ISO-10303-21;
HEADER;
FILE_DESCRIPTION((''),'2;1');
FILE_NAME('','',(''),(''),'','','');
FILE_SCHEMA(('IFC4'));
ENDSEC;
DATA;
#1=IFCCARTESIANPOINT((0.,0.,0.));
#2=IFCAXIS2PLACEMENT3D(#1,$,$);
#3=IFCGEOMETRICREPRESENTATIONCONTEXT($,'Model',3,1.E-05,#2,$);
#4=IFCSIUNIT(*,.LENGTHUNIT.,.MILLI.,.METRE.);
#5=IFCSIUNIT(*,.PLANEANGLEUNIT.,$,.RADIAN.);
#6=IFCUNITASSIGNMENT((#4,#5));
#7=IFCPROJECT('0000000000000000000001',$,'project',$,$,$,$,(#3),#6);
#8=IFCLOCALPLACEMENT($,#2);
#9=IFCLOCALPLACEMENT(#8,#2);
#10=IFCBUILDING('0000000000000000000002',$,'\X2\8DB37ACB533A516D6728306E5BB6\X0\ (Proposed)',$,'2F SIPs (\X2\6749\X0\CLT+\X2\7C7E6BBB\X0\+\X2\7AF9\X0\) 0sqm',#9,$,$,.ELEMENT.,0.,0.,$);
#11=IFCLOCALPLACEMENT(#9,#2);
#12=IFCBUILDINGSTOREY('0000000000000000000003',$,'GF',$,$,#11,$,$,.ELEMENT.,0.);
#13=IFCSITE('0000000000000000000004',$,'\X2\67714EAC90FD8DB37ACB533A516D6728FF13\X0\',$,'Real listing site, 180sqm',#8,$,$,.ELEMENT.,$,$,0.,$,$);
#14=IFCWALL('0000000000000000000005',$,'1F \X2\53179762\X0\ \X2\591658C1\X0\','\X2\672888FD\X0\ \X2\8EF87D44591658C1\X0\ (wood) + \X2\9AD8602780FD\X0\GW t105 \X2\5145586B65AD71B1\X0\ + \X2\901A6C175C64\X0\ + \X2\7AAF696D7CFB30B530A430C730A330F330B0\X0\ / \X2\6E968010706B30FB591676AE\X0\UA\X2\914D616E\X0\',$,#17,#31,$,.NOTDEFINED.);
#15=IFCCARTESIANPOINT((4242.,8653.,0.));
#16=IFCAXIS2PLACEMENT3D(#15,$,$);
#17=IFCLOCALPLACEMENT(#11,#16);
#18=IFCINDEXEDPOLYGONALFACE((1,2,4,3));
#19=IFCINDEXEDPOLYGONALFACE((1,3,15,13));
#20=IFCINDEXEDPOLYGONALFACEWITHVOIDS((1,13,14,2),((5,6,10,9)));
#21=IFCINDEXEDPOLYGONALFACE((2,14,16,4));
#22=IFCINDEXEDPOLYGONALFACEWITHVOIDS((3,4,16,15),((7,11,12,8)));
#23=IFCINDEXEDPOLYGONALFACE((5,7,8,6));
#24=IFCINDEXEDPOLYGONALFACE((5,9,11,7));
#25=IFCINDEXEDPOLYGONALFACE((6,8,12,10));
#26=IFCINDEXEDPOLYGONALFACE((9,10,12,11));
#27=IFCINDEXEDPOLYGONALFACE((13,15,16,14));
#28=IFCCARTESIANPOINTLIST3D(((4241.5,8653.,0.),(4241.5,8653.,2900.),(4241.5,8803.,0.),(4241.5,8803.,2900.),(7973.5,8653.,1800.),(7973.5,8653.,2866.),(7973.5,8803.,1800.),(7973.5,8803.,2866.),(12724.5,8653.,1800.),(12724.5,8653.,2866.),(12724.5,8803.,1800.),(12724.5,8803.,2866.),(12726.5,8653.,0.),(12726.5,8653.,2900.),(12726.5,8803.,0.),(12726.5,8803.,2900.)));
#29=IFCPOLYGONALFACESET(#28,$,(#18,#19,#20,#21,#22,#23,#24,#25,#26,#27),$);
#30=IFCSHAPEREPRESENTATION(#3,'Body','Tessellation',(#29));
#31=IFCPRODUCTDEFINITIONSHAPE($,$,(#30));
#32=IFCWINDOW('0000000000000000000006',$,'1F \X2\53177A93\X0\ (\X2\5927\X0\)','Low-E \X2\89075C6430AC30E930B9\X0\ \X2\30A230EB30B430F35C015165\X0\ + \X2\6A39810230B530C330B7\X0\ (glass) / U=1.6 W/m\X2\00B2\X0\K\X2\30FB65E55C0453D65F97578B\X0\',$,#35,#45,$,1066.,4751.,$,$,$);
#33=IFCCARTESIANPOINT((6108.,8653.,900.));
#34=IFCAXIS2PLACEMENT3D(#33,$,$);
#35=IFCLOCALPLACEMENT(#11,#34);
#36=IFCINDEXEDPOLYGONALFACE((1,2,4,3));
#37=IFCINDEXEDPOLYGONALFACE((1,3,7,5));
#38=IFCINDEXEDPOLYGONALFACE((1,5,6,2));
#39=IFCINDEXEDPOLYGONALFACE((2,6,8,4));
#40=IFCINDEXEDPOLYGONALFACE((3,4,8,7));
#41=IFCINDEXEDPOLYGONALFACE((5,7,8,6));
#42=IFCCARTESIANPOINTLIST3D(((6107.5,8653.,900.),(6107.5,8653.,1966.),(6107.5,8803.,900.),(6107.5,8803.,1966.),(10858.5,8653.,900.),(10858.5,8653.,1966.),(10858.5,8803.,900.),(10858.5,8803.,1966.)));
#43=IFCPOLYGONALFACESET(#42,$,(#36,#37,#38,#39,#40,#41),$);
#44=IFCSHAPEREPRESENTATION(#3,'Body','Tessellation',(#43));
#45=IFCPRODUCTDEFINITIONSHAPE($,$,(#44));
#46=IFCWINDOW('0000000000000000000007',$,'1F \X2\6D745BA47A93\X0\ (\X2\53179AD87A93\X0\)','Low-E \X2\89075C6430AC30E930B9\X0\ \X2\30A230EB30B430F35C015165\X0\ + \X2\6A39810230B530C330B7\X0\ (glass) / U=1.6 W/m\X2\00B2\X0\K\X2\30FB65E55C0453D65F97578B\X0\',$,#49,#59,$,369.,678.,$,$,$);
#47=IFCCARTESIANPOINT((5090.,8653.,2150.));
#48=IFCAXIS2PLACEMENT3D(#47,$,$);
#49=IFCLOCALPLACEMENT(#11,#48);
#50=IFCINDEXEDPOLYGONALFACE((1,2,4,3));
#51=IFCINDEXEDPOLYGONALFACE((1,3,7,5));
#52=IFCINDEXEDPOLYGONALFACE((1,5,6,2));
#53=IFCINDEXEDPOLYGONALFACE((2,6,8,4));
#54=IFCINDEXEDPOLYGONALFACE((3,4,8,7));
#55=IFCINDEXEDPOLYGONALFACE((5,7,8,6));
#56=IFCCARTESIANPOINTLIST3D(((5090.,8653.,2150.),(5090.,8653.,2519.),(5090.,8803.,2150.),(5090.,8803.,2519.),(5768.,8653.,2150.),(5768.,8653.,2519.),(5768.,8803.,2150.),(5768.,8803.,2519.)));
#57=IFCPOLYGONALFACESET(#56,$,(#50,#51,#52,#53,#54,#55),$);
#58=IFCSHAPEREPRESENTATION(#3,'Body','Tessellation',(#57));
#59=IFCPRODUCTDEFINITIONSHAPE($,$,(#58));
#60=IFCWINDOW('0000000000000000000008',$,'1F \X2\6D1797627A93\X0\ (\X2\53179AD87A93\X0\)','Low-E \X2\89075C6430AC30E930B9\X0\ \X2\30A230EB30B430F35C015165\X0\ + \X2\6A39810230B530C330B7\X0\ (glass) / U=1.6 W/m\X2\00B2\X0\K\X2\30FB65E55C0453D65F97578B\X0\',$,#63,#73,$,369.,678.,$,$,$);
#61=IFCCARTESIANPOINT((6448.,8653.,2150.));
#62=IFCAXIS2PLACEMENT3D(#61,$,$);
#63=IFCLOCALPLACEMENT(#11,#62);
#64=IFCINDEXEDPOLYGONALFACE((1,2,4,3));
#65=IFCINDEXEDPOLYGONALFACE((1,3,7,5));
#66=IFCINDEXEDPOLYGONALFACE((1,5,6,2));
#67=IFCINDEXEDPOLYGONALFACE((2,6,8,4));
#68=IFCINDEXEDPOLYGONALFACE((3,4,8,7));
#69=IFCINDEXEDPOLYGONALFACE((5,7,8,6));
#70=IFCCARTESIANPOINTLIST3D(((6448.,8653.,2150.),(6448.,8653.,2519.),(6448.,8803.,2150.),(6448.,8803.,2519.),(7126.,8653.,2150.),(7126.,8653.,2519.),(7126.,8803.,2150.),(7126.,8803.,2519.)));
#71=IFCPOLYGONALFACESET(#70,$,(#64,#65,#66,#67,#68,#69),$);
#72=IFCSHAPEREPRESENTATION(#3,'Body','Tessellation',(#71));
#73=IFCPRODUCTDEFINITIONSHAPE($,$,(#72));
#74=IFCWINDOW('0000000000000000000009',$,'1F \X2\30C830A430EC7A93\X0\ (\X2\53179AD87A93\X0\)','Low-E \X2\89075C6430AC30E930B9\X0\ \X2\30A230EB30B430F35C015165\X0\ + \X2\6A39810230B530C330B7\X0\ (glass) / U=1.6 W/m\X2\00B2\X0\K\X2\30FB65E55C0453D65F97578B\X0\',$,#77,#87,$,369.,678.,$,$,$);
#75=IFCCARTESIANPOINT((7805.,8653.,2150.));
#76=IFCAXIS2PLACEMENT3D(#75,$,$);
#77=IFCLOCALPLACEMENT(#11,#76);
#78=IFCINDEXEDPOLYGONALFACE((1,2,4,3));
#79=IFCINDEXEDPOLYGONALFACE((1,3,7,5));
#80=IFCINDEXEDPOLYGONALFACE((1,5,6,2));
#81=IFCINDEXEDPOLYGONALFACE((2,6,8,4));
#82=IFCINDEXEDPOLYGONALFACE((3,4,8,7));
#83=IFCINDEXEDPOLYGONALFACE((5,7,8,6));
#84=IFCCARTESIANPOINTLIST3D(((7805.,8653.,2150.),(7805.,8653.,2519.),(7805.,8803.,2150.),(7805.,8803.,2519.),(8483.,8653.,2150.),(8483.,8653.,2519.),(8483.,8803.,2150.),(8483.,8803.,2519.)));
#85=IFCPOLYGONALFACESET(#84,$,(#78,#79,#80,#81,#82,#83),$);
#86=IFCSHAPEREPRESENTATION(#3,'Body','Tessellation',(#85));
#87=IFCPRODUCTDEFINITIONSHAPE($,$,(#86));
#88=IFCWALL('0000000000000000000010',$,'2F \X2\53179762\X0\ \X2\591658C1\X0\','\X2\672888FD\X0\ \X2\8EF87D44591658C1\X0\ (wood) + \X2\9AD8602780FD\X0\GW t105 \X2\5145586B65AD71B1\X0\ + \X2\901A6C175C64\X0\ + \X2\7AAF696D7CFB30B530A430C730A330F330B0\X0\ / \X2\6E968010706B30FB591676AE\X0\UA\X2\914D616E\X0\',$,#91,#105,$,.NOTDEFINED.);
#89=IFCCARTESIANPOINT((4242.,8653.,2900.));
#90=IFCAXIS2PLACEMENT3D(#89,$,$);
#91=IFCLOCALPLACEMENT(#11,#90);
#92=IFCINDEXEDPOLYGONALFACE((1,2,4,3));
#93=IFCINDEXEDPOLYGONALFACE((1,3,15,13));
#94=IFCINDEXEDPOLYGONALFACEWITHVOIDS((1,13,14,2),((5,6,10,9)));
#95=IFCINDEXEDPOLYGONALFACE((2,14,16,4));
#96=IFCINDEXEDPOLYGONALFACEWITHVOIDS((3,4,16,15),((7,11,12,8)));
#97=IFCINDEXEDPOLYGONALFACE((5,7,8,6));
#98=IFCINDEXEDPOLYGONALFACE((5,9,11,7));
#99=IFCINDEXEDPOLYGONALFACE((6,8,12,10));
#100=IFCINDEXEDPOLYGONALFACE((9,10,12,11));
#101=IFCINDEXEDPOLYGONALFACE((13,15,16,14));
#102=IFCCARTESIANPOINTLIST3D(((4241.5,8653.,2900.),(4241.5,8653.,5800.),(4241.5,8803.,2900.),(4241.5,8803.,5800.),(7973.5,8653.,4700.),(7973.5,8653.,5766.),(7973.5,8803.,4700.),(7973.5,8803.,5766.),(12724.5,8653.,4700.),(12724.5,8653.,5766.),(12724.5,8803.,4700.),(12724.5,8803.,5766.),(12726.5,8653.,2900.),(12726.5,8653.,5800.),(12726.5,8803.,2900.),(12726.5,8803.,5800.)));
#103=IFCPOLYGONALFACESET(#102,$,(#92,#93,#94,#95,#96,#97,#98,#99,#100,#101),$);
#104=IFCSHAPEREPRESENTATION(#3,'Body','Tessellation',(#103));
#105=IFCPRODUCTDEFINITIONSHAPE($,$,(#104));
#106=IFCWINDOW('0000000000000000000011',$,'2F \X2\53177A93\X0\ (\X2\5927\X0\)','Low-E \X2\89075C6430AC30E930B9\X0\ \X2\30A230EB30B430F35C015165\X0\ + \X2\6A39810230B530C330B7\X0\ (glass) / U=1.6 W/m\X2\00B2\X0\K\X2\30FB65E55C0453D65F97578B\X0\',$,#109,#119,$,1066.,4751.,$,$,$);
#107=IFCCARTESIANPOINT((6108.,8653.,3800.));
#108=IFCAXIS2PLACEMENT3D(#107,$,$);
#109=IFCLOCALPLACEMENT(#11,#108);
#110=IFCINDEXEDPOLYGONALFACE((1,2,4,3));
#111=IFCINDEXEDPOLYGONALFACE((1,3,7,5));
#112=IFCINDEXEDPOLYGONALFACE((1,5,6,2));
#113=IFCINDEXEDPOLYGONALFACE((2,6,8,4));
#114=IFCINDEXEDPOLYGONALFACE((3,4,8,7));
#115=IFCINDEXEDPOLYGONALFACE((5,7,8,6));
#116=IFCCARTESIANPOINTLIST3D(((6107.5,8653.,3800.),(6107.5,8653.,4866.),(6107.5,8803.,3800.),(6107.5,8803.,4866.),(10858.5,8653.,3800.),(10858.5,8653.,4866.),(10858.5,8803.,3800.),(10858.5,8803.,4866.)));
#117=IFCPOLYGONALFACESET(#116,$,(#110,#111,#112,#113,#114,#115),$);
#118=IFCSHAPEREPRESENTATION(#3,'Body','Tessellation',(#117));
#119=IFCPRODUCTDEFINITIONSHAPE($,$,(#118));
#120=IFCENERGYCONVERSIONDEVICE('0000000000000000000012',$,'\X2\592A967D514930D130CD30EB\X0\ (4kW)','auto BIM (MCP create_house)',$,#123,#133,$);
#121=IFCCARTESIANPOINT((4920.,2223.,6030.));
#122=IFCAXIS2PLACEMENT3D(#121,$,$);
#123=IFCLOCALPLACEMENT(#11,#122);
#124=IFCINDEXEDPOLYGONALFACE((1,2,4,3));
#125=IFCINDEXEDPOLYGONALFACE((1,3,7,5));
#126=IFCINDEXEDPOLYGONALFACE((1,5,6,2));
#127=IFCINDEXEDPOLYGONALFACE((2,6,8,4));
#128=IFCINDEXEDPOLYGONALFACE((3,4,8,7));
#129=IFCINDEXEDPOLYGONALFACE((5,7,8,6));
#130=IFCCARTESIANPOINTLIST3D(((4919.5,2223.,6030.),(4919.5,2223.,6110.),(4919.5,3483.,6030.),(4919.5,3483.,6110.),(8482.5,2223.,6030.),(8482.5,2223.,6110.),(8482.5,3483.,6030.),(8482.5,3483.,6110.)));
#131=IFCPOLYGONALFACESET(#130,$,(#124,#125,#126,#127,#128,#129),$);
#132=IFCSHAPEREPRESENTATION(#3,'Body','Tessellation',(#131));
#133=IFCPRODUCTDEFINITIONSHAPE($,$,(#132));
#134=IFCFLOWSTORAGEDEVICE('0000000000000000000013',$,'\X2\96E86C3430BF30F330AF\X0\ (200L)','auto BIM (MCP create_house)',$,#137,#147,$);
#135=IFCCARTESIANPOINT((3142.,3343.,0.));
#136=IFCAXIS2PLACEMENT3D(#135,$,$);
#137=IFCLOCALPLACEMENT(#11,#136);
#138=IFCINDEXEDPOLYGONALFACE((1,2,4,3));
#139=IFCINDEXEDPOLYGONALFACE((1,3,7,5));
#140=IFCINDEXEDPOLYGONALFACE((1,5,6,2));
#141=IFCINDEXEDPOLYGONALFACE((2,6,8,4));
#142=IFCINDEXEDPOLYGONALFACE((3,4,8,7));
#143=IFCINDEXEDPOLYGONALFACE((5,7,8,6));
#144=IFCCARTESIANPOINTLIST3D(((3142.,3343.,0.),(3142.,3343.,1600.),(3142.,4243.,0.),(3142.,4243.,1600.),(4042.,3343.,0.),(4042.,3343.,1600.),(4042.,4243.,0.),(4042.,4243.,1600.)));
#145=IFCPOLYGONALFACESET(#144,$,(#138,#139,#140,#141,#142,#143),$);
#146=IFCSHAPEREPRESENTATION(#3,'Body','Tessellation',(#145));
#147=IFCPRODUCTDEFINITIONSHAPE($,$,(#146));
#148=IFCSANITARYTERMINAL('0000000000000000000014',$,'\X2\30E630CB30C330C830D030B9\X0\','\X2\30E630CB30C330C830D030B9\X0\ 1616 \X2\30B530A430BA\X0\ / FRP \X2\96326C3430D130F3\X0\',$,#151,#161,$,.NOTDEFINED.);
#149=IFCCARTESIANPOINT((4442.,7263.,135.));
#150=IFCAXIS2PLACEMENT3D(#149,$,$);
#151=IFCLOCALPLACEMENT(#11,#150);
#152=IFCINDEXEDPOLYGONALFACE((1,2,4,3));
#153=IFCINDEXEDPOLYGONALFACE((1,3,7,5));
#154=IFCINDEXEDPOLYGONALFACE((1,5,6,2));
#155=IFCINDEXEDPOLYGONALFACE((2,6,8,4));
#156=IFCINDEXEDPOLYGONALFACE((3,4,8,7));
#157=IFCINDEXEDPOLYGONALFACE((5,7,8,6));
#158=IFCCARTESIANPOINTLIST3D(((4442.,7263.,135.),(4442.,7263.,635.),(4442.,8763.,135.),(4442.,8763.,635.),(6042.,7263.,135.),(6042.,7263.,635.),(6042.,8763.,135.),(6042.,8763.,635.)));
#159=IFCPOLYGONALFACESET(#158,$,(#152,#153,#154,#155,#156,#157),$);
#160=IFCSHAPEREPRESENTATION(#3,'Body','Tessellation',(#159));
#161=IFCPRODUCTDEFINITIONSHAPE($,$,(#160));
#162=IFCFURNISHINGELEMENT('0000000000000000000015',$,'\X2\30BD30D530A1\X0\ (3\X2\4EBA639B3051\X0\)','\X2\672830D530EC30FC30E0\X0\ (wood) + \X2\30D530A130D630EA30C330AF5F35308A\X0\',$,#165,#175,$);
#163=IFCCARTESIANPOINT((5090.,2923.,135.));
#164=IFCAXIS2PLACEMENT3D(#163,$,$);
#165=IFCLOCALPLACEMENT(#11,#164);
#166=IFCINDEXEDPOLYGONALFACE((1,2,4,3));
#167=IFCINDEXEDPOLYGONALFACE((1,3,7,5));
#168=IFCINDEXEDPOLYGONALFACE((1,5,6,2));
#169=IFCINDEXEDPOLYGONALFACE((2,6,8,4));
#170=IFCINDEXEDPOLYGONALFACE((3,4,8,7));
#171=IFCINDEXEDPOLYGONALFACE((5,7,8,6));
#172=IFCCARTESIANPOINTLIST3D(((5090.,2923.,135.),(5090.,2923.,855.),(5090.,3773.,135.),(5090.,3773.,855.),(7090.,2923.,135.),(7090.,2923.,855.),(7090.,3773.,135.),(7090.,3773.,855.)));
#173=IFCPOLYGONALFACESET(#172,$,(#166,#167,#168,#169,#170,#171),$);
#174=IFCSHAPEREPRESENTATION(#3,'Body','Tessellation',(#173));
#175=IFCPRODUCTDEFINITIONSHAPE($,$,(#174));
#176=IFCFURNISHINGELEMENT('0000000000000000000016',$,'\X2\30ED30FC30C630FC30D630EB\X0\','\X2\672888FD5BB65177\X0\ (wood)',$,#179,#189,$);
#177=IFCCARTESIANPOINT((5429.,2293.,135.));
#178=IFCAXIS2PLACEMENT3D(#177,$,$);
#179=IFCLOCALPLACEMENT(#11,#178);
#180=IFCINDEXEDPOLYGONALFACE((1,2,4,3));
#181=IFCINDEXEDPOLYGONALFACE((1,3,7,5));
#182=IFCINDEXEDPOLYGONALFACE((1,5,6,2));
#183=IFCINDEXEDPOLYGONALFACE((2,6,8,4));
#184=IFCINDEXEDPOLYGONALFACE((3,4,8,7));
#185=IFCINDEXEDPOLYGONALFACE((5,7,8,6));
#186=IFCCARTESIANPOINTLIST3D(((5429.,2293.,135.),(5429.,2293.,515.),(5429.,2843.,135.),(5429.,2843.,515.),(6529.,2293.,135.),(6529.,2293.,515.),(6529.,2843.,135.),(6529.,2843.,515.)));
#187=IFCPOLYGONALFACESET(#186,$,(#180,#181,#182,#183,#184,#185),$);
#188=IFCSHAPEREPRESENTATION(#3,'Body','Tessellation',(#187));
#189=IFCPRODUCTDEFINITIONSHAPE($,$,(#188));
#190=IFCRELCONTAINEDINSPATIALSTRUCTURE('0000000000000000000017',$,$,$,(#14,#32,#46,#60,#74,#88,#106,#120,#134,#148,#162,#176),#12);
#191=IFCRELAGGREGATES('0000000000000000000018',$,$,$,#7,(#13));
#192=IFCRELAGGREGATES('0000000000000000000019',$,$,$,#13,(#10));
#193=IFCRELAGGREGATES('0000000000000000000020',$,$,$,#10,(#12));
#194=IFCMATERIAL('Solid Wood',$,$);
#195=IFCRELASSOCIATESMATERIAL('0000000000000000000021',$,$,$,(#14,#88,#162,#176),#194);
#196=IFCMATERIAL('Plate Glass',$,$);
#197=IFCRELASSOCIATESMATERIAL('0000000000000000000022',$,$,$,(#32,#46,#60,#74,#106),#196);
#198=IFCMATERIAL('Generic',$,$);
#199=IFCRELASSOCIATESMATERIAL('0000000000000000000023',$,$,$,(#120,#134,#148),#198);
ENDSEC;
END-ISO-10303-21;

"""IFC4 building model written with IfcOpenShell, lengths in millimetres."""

from ifc_helpers import new_model, si_unit, frame, frame_2d, origin, place, context, project, spatial, rectangle, extrude, material, element, fill, save


model = new_model("IFC4")

# Units and contexts
model_context = context("Model", 3, precision=1e-05, world=origin())
ifc_project = project(units=[si_unit("LENGTHUNIT", "METRE", prefix="MILLI"), si_unit("PLANEANGLEUNIT", "RADIAN")], contexts=[model_context])

# Site, building, storey
site_placement = place(None, origin())
site = spatial("IfcSite", under=ifc_project, at=site_placement, Name="東京都足立区六木３", ObjectType="Real listing site, 180sqm", CompositionType="ELEMENT", RefElevation=0.0)
building_placement = place(site_placement, origin())
building = spatial("IfcBuilding", under=site, at=building_placement, Name="足立区六木の家 (Proposed)", ObjectType="2F SIPs (杉CLT+籾殻+竹) 0sqm", CompositionType="ELEMENT", ElevationOfRefHeight=0.0, ElevationOfTerrain=0.0)
storey_placement = place(building_placement, origin())
storey = spatial("IfcBuildingStorey", under=building, at=storey_placement, Name="GF", CompositionType="ELEMENT", Elevation=0.0)

# Wall, openings, windows
ifc_material_1 = material(Name="Solid Wood")
wall_1_placement = place(storey_placement, frame((4242.0, 8653.0, 0.0)))
wall_1 = element("IfcWall", 1, at=wall_1_placement, inside=storey, material=ifc_material_1, Name="1F 北面 外壁", Description="木製 軸組外壁 (wood) + 高性能GW t105 充填断熱 + 通気層 + 窯業系サイディング / 準耐火・外皮UA配慮", PredefinedType="NOTDEFINED", context=model_context, shape_type="SweptSolid", body=[
    extrude(rectangle(XDim=8485.0, YDim=150.0, at=frame_2d((4242.0, 75.0))), frame((4242.0, 8653.0, 0.0)), (0.0, 0.0, 1.0), 2900.0),
])
opening_1_placement = place(storey_placement, frame((6108.0, 8653.0, 900.0)))
opening_1 = element("IfcOpeningElement", 2, at=opening_1_placement, cuts=wall_1, PredefinedType="NOTDEFINED", context=model_context, shape_type="SweptSolid", body=[
    extrude(rectangle(XDim=4751.0, YDim=150.0, at=frame_2d((2375.0, 75.0))), frame((6108.0, 8653.0, 900.0)), (0.0, 0.0, 1.0), 1066.0),
])
opening_2_placement = place(storey_placement, frame((5090.0, 8653.0, 2150.0)))
opening_2 = element("IfcOpeningElement", 3, at=opening_2_placement, cuts=wall_1, PredefinedType="NOTDEFINED", context=model_context, shape_type="SweptSolid", body=[
    extrude(rectangle(XDim=678.0, YDim=150.0, at=frame_2d((339.0, 75.0))), frame((5090.0, 8653.0, 2150.0)), (0.0, 0.0, 1.0), 369.0),
])
opening_3_placement = place(storey_placement, frame((6448.0, 8653.0, 2150.0)))
opening_3 = element("IfcOpeningElement", 4, at=opening_3_placement, cuts=wall_1, PredefinedType="NOTDEFINED", context=model_context, shape_type="SweptSolid", body=[
    extrude(rectangle(XDim=678.0, YDim=150.0, at=frame_2d((339.0, 75.0))), frame((6448.0, 8653.0, 2150.0)), (0.0, 0.0, 1.0), 369.0),
])
opening_4_placement = place(storey_placement, frame((7805.0, 8653.0, 2150.0)))
opening_4 = element("IfcOpeningElement", 5, at=opening_4_placement, cuts=wall_1, PredefinedType="NOTDEFINED", context=model_context, shape_type="SweptSolid", body=[
    extrude(rectangle(XDim=678.0, YDim=150.0, at=frame_2d((339.0, 75.0))), frame((7805.0, 8653.0, 2150.0)), (0.0, 0.0, 1.0), 369.0),
])
ifc_material_2 = material(Name="Plate Glass")
window_1_placement = place(storey_placement, frame((6108.0, 8653.0, 900.0)))
window_1 = element("IfcWindow", 6, at=window_1_placement, inside=storey, material=ifc_material_2, Name="1F 北窓 (大)", Description="Low-E 複層ガラス アルゴン封入 + 樹脂サッシ (glass) / U=1.6 W/m²K・日射取得型", OverallHeight=1066.0, OverallWidth=4751.0, context=model_context, shape_type="SweptSolid", body=[
    extrude(rectangle(XDim=4751.0, YDim=150.0, at=frame_2d((2375.0, 75.0))), frame((6108.0, 8653.0, 900.0)), (0.0, 0.0, 1.0), 1066.0),
])
fill(opening_1, window_1)
window_2_placement = place(storey_placement, frame((5090.0, 8653.0, 2150.0)))
window_2 = element("IfcWindow", 7, at=window_2_placement, inside=storey, material=ifc_material_2, Name="1F 浴室窓 (北高窓)", Description="Low-E 複層ガラス アルゴン封入 + 樹脂サッシ (glass) / U=1.6 W/m²K・日射取得型", OverallHeight=369.0, OverallWidth=678.0, context=model_context, shape_type="SweptSolid", body=[
    extrude(rectangle(XDim=678.0, YDim=150.0, at=frame_2d((339.0, 75.0))), frame((5090.0, 8653.0, 2150.0)), (0.0, 0.0, 1.0), 369.0),
])
fill(opening_2, window_2)
window_3_placement = place(storey_placement, frame((6448.0, 8653.0, 2150.0)))
window_3 = element("IfcWindow", 8, at=window_3_placement, inside=storey, material=ifc_material_2, Name="1F 洗面窓 (北高窓)", Description="Low-E 複層ガラス アルゴン封入 + 樹脂サッシ (glass) / U=1.6 W/m²K・日射取得型", OverallHeight=369.0, OverallWidth=678.0, context=model_context, shape_type="SweptSolid", body=[
    extrude(rectangle(XDim=678.0, YDim=150.0, at=frame_2d((339.0, 75.0))), frame((6448.0, 8653.0, 2150.0)), (0.0, 0.0, 1.0), 369.0),
])
fill(opening_3, window_3)
window_4_placement = place(storey_placement, frame((7805.0, 8653.0, 2150.0)))
window_4 = element("IfcWindow", 9, at=window_4_placement, inside=storey, material=ifc_material_2, Name="1F トイレ窓 (北高窓)", Description="Low-E 複層ガラス アルゴン封入 + 樹脂サッシ (glass) / U=1.6 W/m²K・日射取得型", OverallHeight=369.0, OverallWidth=678.0, context=model_context, shape_type="SweptSolid", body=[
    extrude(rectangle(XDim=678.0, YDim=150.0, at=frame_2d((339.0, 75.0))), frame((7805.0, 8653.0, 2150.0)), (0.0, 0.0, 1.0), 369.0),
])
fill(opening_4, window_4)

# Wall, opening, window
wall_2_placement = place(storey_placement, frame((4242.0, 8653.0, 2900.0)))
wall_2 = element("IfcWall", 10, at=wall_2_placement, inside=storey, material=ifc_material_1, Name="2F 北面 外壁", Description="木製 軸組外壁 (wood) + 高性能GW t105 充填断熱 + 通気層 + 窯業系サイディング / 準耐火・外皮UA配慮", PredefinedType="NOTDEFINED", context=model_context, shape_type="SweptSolid", body=[
    extrude(rectangle(XDim=8485.0, YDim=150.0, at=frame_2d((4242.0, 75.0))), frame((4242.0, 8653.0, 2900.0)), (0.0, 0.0, 1.0), 2900.0),
])
opening_5_placement = place(storey_placement, frame((6108.0, 8653.0, 3800.0)))
opening_5 = element("IfcOpeningElement", 11, at=opening_5_placement, cuts=wall_2, PredefinedType="NOTDEFINED", context=model_context, shape_type="SweptSolid", body=[
    extrude(rectangle(XDim=4751.0, YDim=150.0, at=frame_2d((2375.0, 75.0))), frame((6108.0, 8653.0, 3800.0)), (0.0, 0.0, 1.0), 1066.0),
])
window_5_placement = place(storey_placement, frame((6108.0, 8653.0, 3800.0)))
window_5 = element("IfcWindow", 12, at=window_5_placement, inside=storey, material=ifc_material_2, Name="2F 北窓 (大)", Description="Low-E 複層ガラス アルゴン封入 + 樹脂サッシ (glass) / U=1.6 W/m²K・日射取得型", OverallHeight=1066.0, OverallWidth=4751.0, context=model_context, shape_type="SweptSolid", body=[
    extrude(rectangle(XDim=4751.0, YDim=150.0, at=frame_2d((2375.0, 75.0))), frame((6108.0, 8653.0, 3800.0)), (0.0, 0.0, 1.0), 1066.0),
])
fill(opening_5, window_5)

# Energy conversion device
ifc_material_3 = material(Name="Generic")
energy_conversion_device_placement = place(storey_placement, frame((4920.0, 2223.0, 6030.0)))
element("IfcEnergyConversionDevice", 13, at=energy_conversion_device_placement, inside=storey, material=ifc_material_3, Name="太陽光パネル (4kW)", Description="auto BIM (MCP create_house)", context=model_context, shape_type="SweptSolid", body=[
    extrude(rectangle(XDim=3563.0, YDim=1260.0, at=frame_2d((1781.0, 630.0))), frame((4920.0, 2223.0, 6030.0)), (0.0, 0.0, 1.0), 80.0),
])

# Flow storage device
flow_storage_device_placement = place(storey_placement, frame((3142.0, 3343.0, 0.0)))
element("IfcFlowStorageDevice", 14, at=flow_storage_device_placement, inside=storey, material=ifc_material_3, Name="雨水タンク (200L)", Description="auto BIM (MCP create_house)", context=model_context, shape_type="SweptSolid", body=[
    extrude(rectangle(XDim=900.0, YDim=900.0, at=frame_2d((450.0, 450.0))), frame((3142.0, 3343.0, 0.0)), (0.0, 0.0, 1.0), 1600.0),
])

# Sanitary terminal
sanitary_terminal_placement = place(storey_placement, frame((4442.0, 7263.0, 135.0)))
element("IfcSanitaryTerminal", 15, at=sanitary_terminal_placement, inside=storey, material=ifc_material_3, Name="ユニットバス", Description="ユニットバス 1616 サイズ / FRP 防水パン", PredefinedType="NOTDEFINED", context=model_context, shape_type="SweptSolid", body=[
    extrude(rectangle(XDim=1600.0, YDim=1500.0, at=frame_2d((800.0, 750.0))), frame((4442.0, 7263.0, 135.0)), (0.0, 0.0, 1.0), 500.0),
])

# Furnishing elements
furnishing_1_placement = place(storey_placement, frame((5090.0, 2923.0, 135.0)))
element("IfcFurnishingElement", 16, at=furnishing_1_placement, inside=storey, material=ifc_material_1, Name="ソファ (3人掛け)", Description="木フレーム (wood) + ファブリック張り", context=model_context, shape_type="SweptSolid", body=[
    extrude(rectangle(XDim=2000.0, YDim=850.0, at=frame_2d((1000.0, 425.0))), frame((5090.0, 2923.0, 135.0)), (0.0, 0.0, 1.0), 720.0),
])
furnishing_2_placement = place(storey_placement, frame((5429.0, 2293.0, 135.0)))
element("IfcFurnishingElement", 17, at=furnishing_2_placement, inside=storey, material=ifc_material_1, Name="ローテーブル", Description="木製家具 (wood)", context=model_context, shape_type="SweptSolid", body=[
    extrude(rectangle(XDim=1100.0, YDim=550.0, at=frame_2d((550.0, 275.0))), frame((5429.0, 2293.0, 135.0)), (0.0, 0.0, 1.0), 380.0),
])

save(model, "model.ifc")
